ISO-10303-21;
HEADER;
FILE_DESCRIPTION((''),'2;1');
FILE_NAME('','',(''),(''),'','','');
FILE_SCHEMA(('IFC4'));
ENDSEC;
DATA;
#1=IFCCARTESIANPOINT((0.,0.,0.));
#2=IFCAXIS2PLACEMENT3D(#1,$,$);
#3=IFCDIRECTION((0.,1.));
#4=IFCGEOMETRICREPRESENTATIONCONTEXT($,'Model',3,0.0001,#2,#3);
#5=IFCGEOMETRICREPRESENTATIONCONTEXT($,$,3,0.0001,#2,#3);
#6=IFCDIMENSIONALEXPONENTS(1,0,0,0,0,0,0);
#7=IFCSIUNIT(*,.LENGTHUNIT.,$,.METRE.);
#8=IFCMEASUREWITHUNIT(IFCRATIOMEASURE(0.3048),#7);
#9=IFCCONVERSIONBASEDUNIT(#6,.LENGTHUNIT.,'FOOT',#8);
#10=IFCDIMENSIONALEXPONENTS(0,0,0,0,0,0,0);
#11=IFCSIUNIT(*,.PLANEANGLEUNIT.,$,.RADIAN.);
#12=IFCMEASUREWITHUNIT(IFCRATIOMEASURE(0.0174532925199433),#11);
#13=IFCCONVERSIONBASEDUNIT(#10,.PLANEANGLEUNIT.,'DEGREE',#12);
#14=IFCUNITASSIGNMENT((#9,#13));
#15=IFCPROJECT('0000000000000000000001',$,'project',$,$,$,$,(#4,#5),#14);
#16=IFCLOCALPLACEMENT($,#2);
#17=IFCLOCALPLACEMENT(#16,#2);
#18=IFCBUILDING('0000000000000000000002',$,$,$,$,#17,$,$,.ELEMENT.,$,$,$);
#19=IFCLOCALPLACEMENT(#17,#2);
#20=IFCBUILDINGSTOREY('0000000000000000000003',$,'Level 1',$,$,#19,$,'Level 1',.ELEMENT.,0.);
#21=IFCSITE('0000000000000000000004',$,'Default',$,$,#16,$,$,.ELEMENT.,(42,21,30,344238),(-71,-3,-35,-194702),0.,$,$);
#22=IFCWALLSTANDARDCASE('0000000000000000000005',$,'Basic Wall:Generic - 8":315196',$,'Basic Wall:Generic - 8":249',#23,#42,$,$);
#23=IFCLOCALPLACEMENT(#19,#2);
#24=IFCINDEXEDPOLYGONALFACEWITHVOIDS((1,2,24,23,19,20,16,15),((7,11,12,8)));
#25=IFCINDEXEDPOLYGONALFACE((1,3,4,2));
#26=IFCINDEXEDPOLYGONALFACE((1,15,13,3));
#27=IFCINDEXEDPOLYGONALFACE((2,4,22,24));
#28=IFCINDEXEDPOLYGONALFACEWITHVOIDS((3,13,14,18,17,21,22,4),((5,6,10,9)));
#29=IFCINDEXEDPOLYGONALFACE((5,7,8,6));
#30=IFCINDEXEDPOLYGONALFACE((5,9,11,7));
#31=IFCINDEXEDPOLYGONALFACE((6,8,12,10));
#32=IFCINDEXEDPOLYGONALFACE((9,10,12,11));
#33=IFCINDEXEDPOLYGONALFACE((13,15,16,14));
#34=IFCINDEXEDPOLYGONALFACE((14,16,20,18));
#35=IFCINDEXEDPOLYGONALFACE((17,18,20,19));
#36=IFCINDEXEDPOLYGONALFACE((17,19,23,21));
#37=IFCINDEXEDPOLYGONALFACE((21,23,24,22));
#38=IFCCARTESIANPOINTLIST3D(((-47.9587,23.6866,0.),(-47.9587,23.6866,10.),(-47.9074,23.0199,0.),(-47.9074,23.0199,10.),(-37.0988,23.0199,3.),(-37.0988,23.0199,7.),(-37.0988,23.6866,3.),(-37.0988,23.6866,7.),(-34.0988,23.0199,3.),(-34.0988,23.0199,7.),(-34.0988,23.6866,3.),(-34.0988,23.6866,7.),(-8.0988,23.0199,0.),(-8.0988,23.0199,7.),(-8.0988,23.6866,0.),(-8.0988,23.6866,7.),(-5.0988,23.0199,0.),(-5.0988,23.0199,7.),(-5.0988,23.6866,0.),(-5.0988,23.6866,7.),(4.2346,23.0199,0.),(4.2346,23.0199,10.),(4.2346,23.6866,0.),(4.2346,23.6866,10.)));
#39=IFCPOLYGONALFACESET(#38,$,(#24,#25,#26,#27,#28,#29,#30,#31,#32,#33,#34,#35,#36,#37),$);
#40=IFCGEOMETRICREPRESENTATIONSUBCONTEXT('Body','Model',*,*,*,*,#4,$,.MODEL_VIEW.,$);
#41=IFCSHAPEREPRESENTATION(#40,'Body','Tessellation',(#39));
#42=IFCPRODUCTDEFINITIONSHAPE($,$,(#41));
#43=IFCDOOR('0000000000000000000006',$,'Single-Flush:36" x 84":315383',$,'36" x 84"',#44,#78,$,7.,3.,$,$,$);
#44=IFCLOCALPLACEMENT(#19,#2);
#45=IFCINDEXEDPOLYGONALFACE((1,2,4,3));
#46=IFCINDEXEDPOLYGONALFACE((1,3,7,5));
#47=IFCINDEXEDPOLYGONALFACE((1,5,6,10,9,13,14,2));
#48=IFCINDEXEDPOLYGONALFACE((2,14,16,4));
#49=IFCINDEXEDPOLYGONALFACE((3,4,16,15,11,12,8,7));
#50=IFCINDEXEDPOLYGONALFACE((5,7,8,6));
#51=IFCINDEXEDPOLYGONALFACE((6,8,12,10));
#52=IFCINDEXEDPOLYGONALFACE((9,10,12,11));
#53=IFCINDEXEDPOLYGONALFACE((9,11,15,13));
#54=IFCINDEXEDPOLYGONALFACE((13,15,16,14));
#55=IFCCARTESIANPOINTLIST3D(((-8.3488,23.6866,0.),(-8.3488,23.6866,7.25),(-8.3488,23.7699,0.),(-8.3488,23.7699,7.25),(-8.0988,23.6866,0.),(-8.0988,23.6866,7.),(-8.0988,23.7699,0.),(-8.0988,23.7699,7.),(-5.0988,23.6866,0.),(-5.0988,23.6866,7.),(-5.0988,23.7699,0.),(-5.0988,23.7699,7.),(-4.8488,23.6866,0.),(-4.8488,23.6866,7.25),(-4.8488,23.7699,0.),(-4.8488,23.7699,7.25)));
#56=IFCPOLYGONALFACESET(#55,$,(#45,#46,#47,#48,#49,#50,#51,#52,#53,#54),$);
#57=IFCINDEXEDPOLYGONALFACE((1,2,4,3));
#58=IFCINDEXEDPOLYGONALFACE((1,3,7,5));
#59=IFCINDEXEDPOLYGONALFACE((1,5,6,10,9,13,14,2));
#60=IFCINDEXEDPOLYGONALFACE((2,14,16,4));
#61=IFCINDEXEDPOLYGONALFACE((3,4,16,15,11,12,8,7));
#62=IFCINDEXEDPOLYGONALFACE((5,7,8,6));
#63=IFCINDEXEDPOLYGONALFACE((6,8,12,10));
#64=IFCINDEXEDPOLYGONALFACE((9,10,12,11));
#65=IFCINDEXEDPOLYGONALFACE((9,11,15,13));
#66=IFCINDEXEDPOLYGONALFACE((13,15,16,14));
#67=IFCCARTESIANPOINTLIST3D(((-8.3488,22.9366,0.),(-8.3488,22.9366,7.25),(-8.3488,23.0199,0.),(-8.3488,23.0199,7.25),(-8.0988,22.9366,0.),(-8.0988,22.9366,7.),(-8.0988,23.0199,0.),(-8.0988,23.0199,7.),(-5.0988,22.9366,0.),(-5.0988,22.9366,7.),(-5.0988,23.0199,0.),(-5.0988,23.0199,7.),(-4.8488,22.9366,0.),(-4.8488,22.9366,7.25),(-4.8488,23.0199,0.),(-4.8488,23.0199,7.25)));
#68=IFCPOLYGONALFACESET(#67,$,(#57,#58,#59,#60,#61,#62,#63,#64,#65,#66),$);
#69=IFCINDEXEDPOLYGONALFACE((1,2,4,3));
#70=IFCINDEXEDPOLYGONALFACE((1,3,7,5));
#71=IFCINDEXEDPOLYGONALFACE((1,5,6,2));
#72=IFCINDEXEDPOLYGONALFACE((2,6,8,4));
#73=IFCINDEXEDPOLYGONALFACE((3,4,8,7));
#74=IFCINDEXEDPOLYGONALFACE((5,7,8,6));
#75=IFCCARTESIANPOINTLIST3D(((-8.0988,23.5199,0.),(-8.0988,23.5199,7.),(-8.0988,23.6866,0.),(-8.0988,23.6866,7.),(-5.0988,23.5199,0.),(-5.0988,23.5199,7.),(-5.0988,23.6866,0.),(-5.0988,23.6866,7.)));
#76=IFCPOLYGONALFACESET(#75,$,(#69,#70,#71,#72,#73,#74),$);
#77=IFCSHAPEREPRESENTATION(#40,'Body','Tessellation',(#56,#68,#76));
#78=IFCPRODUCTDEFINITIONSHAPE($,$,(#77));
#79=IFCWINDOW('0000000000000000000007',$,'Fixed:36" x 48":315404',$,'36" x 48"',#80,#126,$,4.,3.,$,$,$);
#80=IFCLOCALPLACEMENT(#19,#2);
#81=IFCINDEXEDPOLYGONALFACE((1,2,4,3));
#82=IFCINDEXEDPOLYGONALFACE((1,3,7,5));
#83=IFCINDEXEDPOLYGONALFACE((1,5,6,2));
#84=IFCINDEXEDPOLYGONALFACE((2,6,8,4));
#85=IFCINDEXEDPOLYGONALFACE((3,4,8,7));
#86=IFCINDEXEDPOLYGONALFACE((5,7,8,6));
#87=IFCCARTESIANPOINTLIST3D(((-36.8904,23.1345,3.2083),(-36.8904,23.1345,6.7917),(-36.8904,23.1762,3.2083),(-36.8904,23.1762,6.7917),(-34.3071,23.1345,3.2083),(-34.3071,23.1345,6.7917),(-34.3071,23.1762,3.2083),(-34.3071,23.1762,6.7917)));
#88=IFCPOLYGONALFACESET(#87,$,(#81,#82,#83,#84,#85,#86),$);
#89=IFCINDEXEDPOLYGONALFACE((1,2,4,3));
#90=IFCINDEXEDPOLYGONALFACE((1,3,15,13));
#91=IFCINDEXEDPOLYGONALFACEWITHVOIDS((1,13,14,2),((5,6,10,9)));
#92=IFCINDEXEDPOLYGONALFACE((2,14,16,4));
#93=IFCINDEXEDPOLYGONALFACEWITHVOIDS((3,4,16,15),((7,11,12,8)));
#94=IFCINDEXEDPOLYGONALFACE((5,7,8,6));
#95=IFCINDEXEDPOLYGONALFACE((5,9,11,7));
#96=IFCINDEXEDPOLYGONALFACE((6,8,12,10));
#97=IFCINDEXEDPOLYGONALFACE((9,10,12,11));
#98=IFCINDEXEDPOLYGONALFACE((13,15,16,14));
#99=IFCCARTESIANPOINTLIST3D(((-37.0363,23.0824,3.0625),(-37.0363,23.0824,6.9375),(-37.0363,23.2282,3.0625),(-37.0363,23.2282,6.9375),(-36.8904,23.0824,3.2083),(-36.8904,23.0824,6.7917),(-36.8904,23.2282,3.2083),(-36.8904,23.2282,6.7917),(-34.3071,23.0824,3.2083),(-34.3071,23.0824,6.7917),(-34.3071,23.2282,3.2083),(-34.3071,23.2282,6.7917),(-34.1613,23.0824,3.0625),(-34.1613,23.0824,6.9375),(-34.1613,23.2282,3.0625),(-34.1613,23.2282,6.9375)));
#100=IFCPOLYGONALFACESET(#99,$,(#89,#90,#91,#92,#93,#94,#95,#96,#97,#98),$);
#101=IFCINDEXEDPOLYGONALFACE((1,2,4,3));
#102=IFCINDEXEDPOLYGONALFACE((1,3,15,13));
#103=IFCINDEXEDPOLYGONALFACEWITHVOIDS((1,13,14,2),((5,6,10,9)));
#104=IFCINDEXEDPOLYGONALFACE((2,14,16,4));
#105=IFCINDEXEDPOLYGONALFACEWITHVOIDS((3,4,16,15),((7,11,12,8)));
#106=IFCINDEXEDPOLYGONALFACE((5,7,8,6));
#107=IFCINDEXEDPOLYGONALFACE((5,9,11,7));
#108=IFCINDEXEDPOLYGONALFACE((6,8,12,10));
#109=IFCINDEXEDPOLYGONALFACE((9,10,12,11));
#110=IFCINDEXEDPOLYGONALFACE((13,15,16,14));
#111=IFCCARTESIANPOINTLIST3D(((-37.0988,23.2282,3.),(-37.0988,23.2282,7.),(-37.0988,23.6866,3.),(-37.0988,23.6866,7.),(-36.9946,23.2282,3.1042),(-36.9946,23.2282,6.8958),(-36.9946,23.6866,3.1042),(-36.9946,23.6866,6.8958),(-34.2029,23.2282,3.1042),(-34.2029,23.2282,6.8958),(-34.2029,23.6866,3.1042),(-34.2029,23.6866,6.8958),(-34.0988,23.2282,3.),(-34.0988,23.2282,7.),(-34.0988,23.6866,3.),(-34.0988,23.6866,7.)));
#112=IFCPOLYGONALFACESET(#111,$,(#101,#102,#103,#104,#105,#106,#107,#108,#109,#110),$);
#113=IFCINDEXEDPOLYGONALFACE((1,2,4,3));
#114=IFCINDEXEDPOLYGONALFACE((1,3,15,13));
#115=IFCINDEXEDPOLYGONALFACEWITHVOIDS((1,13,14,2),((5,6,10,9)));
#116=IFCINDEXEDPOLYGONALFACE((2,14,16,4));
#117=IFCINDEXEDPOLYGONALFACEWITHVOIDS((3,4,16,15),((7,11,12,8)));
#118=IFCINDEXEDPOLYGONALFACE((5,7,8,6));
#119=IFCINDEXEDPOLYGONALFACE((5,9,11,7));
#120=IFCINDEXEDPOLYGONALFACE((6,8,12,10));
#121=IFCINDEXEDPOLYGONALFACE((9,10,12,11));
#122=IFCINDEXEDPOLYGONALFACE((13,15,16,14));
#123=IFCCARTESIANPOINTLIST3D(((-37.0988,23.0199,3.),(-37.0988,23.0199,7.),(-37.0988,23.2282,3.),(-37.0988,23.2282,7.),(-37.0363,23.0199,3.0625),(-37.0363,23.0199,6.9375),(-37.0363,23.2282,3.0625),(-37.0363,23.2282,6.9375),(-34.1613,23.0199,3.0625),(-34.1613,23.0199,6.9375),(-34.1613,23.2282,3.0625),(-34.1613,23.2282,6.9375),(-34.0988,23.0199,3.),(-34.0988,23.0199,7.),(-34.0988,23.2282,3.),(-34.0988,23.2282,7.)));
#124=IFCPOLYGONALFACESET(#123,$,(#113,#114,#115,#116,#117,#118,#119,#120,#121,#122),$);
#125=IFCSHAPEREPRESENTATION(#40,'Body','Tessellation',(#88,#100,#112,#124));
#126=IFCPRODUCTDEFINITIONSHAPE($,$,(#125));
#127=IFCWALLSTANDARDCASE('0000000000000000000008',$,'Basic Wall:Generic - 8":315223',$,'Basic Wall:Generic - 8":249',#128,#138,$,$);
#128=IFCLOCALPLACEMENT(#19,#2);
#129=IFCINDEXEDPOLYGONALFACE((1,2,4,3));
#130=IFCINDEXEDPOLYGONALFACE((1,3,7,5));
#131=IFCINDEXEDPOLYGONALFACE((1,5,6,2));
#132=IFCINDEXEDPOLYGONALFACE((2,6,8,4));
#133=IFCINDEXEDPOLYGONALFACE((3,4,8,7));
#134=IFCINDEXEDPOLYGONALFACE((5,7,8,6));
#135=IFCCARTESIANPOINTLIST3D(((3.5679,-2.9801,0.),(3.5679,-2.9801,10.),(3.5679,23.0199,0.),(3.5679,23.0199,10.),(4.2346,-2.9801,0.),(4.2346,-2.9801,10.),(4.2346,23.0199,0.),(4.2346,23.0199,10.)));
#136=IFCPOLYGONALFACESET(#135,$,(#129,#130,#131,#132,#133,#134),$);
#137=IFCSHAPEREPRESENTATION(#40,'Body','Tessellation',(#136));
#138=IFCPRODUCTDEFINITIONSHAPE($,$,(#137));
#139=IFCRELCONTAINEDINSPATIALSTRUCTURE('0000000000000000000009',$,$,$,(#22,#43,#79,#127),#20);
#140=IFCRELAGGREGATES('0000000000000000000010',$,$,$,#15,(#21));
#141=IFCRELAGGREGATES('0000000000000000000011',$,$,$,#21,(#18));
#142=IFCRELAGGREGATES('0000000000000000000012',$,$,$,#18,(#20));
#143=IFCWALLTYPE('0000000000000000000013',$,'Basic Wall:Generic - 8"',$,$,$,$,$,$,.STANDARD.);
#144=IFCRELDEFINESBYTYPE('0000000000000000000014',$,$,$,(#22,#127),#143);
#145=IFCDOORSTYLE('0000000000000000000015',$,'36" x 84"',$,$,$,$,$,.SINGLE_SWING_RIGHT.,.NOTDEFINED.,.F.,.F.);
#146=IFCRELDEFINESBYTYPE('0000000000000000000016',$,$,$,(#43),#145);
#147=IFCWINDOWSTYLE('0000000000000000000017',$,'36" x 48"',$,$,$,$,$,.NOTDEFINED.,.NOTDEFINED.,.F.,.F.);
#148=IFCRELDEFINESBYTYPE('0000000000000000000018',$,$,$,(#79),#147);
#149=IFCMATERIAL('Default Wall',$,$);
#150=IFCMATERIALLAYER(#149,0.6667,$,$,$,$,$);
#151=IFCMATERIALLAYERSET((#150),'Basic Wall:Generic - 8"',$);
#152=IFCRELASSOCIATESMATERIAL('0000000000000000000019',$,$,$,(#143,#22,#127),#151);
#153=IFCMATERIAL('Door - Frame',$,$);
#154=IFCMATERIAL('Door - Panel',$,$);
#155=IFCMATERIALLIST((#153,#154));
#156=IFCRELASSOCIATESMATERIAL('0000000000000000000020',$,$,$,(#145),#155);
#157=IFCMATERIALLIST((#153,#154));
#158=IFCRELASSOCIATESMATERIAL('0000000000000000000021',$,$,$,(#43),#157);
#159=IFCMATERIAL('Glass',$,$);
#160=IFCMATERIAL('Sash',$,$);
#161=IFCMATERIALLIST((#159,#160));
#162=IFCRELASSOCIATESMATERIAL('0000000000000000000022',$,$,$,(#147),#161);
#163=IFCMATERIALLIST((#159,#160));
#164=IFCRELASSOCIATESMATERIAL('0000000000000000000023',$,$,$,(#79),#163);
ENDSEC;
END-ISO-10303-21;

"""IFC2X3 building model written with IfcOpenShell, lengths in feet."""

from ifc_helpers import new_model, entity, si_unit, converted_unit, direction, frame, frame_2d, origin, place, context, subcontext, project, spatial, polyline, rectangle, outline, extrude, clip, bounded_halfspace, source, transform, mapped, material, material_list, layer, layer_set, layer_usage, type_object, type_shapes, element, fill, save


model = new_model("IFC2X3")

# Units and contexts
model_context = context("Model", 3, precision=0.0001, world=origin(), true_north=direction((0.0, 1.0)))
context_of_model = context(None, 3, precision=0.0001, world=origin(), true_north=direction((0.0, 1.0)))
body_context = subcontext(model_context, "Body", "Model", "MODEL_VIEW")
ifc_project = project(units=[converted_unit("LENGTHUNIT", "FOOT", entity("IfcRatioMeasure", 0.3048), si_unit("LENGTHUNIT", "METRE"), dimensions=[1, 0, 0, 0, 0, 0, 0]), converted_unit("PLANEANGLEUNIT", "DEGREE", entity("IfcRatioMeasure", 0.0174532925199433), si_unit("PLANEANGLEUNIT", "RADIAN"), dimensions=[0, 0, 0, 0, 0, 0, 0])], contexts=[model_context, context_of_model])

# Site, building, storey
site_placement = place(None, origin())
site = spatial("IfcSite", under=ifc_project, at=site_placement, Name="Default", CompositionType="ELEMENT", RefLatitude=(42, 21, 30, 344238), RefLongitude=(-71, -3, -35, -194702), RefElevation=0.0)
building_placement = place(site_placement, origin())
building = spatial("IfcBuilding", under=site, at=building_placement, CompositionType="ELEMENT")
storey_placement = place(building_placement, origin())
storey = spatial("IfcBuildingStorey", under=building, at=storey_placement, Name="Level 1", LongName="Level 1", CompositionType="ELEMENT", Elevation=0.0)

# Wall, openings, door, window
ifc_material_1 = material(Name="Default Wall")
ifc_layer_1 = layer(ifc_material_1, 0.6667)
ifc_layer_set_1 = layer_set([ifc_layer_1], Name="Basic Wall:Generic - 8\"")
ifc_layer_usage_1 = layer_usage(ifc_layer_set_1, "AXIS2", "NEGATIVE", 0.3333)
wall_type = type_object("IfcWallType", Name="Basic Wall:Generic - 8\"", PredefinedType="STANDARD", material=ifc_layer_set_1)
wall_1_placement = place(storey_placement, frame((-47.9587, 23.3532, 0.0)))
wall_1 = element("IfcWallStandardCase", 1, at=wall_1_placement, inside=storey, type_object=wall_type, material=ifc_layer_usage_1, Name="Basic Wall:Generic - 8\":315196", ObjectType="Basic Wall:Generic - 8\":249", context=body_context, shape_type="Clipping", body=[
    clip(extrude(outline(polyline([(0.0513, -0.3333), (0.7199, -0.3333), (25.8013, -0.3333), (26.4699, -0.3333), (51.5266, -0.3333), (52.1933, -0.3333), (52.1933, 0.3333), (0.0, 0.3333), (0.0513, -0.3333)])), origin(), (0.0, 0.0, 1.0), 10.0), bounded_halfspace(frame((0.0513, -0.3333, 10.0)), False, frame((0.0513, -0.3333, 10.0)), polyline([(0.0, 0.0), (0.6686, 0.0), (25.75, 0.0), (26.4186, 0.0), (51.4753, 0.0), (52.142, 0.0), (52.142, 0.6667), (-0.0513, 0.6667), (0.0, 0.0)]))),
])
opening_1_placement = place(wall_1_placement, frame((39.86, -0.3333, 0.0)))
opening_1 = element("IfcOpeningElement", 2, at=opening_1_placement, cuts=wall_1, ObjectType="Opening", context=body_context, shape_type="SweptSolid", body=[
    extrude(rectangle(XDim=3.0, YDim=7.0, at=frame_2d((3.5, 1.5), x_axis=(0.0, 1.0))), frame((0.0, 0.0, 0.0), z_axis=(0.0, 1.0, 0.0), x_axis=(0.0, 0.0, 1.0)), (0.0, 0.0, 1.0), 0.6667),
])
opening_2_placement = place(wall_1_placement, frame((13.86, 0.3333, 3.0)))
opening_2 = element("IfcOpeningElement", 3, at=opening_2_placement, cuts=wall_1, ObjectType="Opening", context=body_context, shape_type="SweptSolid", body=[
    extrude(rectangle(XDim=4.0, YDim=3.0, at=frame_2d((2.0, 1.5), x_axis=(-1.0, 0.0))), frame((0.0, 0.0, 0.0), z_axis=(0.0, -1.0, 0.0), x_axis=(0.0, 0.0, 1.0)), (0.0, 0.0, 1.0), 0.6667),
])
ifc_material_2 = material(Name="Door - Frame")
ifc_material_3 = material(Name="Door - Panel")
ifc_material_list_1 = material_list([ifc_material_2, ifc_material_3])
ifc_material_list_2 = material_list([ifc_material_2, ifc_material_3])
door_style = type_object("IfcDoorStyle", Name="36\" x 84\"", ConstructionType="NOTDEFINED", OperationType="SINGLE_SWING_RIGHT", ParameterTakesPrecedence=False, Sizeable=False, material=ifc_material_list_2)
shared_shape_1 = source(origin(), body_context, "Body", "SweptSolid", [
    extrude(outline(polyline([(-1.75, -3.6875), (1.75, -3.6875), (1.75, 3.5625), (1.5, 3.5625), (1.5, -3.4375), (-1.5, -3.4375), (-1.5, 3.5625), (-1.75, 3.5625), (-1.75, -3.6875)])), frame((1.5, 0.6667, 3.5625), z_axis=(0.0, 1.0, 0.0), x_axis=(1.0, 0.0, 0.0)), (0.0, 0.0, 1.0), 0.0833),
    extrude(outline(polyline([(-3.6875, -1.75), (3.5625, -1.75), (3.5625, -1.5), (-3.4375, -1.5), (-3.4375, 1.5), (3.5625, 1.5), (3.5625, 1.75), (-3.6875, 1.75), (-3.6875, -1.75)])), frame((1.5, -0.0833, 3.5625), z_axis=(0.0, 1.0, 0.0), x_axis=(0.0, 0.0, -1.0)), (0.0, 0.0, 1.0), 0.0833),
    extrude(rectangle(XDim=0.1667, YDim=3.0, at=frame_2d((0.0, 0.0), x_axis=(1.0, 0.0))), frame((1.5, 0.5833, 0.0), z_axis=(0.0, 0.0, 1.0), x_axis=(0.0, 1.0, 0.0)), (0.0, 0.0, 1.0), 7.0),
])
type_shapes(door_style, [shared_shape_1])
door_1_placement = place(opening_1_placement, origin())
door_1 = element("IfcDoor", 4, at=door_1_placement, inside=storey, type_object=door_style, material=ifc_material_list_1, Name="Single-Flush:36\" x 84\":315383", ObjectType="36\" x 84\"", OverallHeight=7.0, OverallWidth=3.0, context=body_context, shape_type="MappedRepresentation", body=[
    mapped(shared_shape_1, transform((0.0, 0.0, 0.0), scale=1.0)),
])
fill(opening_1, door_1)
ifc_material_4 = material(Name="Glass")
ifc_material_5 = material(Name="Sash")
ifc_material_list_3 = material_list([ifc_material_4, ifc_material_5])
ifc_material_list_4 = material_list([ifc_material_4, ifc_material_5])
window_style = type_object("IfcWindowStyle", Name="36\" x 48\"", ConstructionType="NOTDEFINED", OperationType="NOTDEFINED", ParameterTakesPrecedence=False, Sizeable=False, material=ifc_material_list_4)
shared_shape_2 = source(origin(), body_context, "Body", "SweptSolid", [
    extrude(rectangle(XDim=0.0417, YDim=2.5833, at=frame_2d((0.0, 0.0), x_axis=(1.0, 0.0))), frame((1.5, 0.5312, 0.2083), z_axis=(0.0, 0.0, 1.0), x_axis=(0.0, 1.0, 0.0)), (0.0, 0.0, 1.0), 3.5833),
    extrude(outline(polyline([(-1.4375, -1.9375), (1.4375, -1.9375), (1.4375, 1.9375), (-1.4375, 1.9375), (-1.4375, -1.9375)]), holes=[polyline([(-1.2917, -1.7917), (-1.2917, 1.7917), (1.2917, 1.7917), (1.2917, -1.7917), (-1.2917, -1.7917)])]), frame((1.5, 0.4583, 2.0), z_axis=(0.0, 1.0, 0.0), x_axis=(1.0, 0.0, 0.0)), (0.0, 0.0, 1.0), 0.1458),
    extrude(outline(polyline([(-1.5, -2.0), (1.5, -2.0), (1.5, 2.0), (-1.5, 2.0), (-1.5, -2.0)]), holes=[polyline([(-1.3958, -1.8958), (-1.3958, 1.8958), (1.3958, 1.8958), (1.3958, -1.8958), (-1.3958, -1.8958)])]), frame((1.5, 0.0, 2.0), z_axis=(0.0, 1.0, 0.0), x_axis=(1.0, 0.0, 0.0)), (0.0, 0.0, 1.0), 0.4583),
    extrude(outline(polyline([(-2.0, -1.5), (2.0, -1.5), (2.0, 1.5), (-2.0, 1.5), (-2.0, -1.5)]), holes=[polyline([(-1.9375, -1.4375), (-1.9375, 1.4375), (1.9375, 1.4375), (1.9375, -1.4375), (-1.9375, -1.4375)])]), frame((1.5, 0.4583, 2.0), z_axis=(0.0, 1.0, 0.0), x_axis=(0.0, 0.0, -1.0)), (0.0, 0.0, 1.0), 0.2083),
])
type_shapes(window_style, [shared_shape_2])
window_1_placement = place(opening_2_placement, frame((0.0, 0.0, 0.0), z_axis=(0.0, 0.0, 1.0), x_axis=(-1.0, 0.0, 0.0)))
window_1 = element("IfcWindow", 5, at=window_1_placement, inside=storey, type_object=window_style, material=ifc_material_list_3, Name="Fixed:36\" x 48\":315404", ObjectType="36\" x 48\"", OverallHeight=4.0, OverallWidth=3.0, context=body_context, shape_type="MappedRepresentation", body=[
    mapped(shared_shape_2, transform((0.0, 0.0, 0.0), scale=1.0)),
])
fill(opening_2, window_1)

# Wall
ifc_layer_usage_2 = layer_usage(ifc_layer_set_1, "AXIS2", "NEGATIVE", 0.3333)
wall_2_placement = place(storey_placement, frame((3.9012, 23.0199, 0.0), z_axis=(0.0, 0.0, 1.0), x_axis=(0.0, -1.0, 0.0)))
element("IfcWallStandardCase", 6, at=wall_2_placement, inside=storey, type_object=wall_type, material=ifc_layer_usage_2, Name="Basic Wall:Generic - 8\":315223", ObjectType="Basic Wall:Generic - 8\":249", context=body_context, shape_type="Clipping", body=[
    clip(extrude(rectangle(XDim=26.0, YDim=0.6667, at=frame_2d((13.0, 0.0), x_axis=(-1.0, 0.0))), origin(), (0.0, 0.0, 1.0), 10.0), bounded_halfspace(frame((0.0, -0.3333, 10.0), z_axis=(0.0, 0.0, 1.0), x_axis=(0.0, 1.0, 0.0)), False, frame((0.0, -0.3333, 10.0)), polyline([(0.0, 0.0), (25.3333, 0.0), (26.0, 0.0), (26.0, 0.6667), (0.0, 0.6667), (0.0, 0.0)]))),
])

save(model, "model.ifc")
